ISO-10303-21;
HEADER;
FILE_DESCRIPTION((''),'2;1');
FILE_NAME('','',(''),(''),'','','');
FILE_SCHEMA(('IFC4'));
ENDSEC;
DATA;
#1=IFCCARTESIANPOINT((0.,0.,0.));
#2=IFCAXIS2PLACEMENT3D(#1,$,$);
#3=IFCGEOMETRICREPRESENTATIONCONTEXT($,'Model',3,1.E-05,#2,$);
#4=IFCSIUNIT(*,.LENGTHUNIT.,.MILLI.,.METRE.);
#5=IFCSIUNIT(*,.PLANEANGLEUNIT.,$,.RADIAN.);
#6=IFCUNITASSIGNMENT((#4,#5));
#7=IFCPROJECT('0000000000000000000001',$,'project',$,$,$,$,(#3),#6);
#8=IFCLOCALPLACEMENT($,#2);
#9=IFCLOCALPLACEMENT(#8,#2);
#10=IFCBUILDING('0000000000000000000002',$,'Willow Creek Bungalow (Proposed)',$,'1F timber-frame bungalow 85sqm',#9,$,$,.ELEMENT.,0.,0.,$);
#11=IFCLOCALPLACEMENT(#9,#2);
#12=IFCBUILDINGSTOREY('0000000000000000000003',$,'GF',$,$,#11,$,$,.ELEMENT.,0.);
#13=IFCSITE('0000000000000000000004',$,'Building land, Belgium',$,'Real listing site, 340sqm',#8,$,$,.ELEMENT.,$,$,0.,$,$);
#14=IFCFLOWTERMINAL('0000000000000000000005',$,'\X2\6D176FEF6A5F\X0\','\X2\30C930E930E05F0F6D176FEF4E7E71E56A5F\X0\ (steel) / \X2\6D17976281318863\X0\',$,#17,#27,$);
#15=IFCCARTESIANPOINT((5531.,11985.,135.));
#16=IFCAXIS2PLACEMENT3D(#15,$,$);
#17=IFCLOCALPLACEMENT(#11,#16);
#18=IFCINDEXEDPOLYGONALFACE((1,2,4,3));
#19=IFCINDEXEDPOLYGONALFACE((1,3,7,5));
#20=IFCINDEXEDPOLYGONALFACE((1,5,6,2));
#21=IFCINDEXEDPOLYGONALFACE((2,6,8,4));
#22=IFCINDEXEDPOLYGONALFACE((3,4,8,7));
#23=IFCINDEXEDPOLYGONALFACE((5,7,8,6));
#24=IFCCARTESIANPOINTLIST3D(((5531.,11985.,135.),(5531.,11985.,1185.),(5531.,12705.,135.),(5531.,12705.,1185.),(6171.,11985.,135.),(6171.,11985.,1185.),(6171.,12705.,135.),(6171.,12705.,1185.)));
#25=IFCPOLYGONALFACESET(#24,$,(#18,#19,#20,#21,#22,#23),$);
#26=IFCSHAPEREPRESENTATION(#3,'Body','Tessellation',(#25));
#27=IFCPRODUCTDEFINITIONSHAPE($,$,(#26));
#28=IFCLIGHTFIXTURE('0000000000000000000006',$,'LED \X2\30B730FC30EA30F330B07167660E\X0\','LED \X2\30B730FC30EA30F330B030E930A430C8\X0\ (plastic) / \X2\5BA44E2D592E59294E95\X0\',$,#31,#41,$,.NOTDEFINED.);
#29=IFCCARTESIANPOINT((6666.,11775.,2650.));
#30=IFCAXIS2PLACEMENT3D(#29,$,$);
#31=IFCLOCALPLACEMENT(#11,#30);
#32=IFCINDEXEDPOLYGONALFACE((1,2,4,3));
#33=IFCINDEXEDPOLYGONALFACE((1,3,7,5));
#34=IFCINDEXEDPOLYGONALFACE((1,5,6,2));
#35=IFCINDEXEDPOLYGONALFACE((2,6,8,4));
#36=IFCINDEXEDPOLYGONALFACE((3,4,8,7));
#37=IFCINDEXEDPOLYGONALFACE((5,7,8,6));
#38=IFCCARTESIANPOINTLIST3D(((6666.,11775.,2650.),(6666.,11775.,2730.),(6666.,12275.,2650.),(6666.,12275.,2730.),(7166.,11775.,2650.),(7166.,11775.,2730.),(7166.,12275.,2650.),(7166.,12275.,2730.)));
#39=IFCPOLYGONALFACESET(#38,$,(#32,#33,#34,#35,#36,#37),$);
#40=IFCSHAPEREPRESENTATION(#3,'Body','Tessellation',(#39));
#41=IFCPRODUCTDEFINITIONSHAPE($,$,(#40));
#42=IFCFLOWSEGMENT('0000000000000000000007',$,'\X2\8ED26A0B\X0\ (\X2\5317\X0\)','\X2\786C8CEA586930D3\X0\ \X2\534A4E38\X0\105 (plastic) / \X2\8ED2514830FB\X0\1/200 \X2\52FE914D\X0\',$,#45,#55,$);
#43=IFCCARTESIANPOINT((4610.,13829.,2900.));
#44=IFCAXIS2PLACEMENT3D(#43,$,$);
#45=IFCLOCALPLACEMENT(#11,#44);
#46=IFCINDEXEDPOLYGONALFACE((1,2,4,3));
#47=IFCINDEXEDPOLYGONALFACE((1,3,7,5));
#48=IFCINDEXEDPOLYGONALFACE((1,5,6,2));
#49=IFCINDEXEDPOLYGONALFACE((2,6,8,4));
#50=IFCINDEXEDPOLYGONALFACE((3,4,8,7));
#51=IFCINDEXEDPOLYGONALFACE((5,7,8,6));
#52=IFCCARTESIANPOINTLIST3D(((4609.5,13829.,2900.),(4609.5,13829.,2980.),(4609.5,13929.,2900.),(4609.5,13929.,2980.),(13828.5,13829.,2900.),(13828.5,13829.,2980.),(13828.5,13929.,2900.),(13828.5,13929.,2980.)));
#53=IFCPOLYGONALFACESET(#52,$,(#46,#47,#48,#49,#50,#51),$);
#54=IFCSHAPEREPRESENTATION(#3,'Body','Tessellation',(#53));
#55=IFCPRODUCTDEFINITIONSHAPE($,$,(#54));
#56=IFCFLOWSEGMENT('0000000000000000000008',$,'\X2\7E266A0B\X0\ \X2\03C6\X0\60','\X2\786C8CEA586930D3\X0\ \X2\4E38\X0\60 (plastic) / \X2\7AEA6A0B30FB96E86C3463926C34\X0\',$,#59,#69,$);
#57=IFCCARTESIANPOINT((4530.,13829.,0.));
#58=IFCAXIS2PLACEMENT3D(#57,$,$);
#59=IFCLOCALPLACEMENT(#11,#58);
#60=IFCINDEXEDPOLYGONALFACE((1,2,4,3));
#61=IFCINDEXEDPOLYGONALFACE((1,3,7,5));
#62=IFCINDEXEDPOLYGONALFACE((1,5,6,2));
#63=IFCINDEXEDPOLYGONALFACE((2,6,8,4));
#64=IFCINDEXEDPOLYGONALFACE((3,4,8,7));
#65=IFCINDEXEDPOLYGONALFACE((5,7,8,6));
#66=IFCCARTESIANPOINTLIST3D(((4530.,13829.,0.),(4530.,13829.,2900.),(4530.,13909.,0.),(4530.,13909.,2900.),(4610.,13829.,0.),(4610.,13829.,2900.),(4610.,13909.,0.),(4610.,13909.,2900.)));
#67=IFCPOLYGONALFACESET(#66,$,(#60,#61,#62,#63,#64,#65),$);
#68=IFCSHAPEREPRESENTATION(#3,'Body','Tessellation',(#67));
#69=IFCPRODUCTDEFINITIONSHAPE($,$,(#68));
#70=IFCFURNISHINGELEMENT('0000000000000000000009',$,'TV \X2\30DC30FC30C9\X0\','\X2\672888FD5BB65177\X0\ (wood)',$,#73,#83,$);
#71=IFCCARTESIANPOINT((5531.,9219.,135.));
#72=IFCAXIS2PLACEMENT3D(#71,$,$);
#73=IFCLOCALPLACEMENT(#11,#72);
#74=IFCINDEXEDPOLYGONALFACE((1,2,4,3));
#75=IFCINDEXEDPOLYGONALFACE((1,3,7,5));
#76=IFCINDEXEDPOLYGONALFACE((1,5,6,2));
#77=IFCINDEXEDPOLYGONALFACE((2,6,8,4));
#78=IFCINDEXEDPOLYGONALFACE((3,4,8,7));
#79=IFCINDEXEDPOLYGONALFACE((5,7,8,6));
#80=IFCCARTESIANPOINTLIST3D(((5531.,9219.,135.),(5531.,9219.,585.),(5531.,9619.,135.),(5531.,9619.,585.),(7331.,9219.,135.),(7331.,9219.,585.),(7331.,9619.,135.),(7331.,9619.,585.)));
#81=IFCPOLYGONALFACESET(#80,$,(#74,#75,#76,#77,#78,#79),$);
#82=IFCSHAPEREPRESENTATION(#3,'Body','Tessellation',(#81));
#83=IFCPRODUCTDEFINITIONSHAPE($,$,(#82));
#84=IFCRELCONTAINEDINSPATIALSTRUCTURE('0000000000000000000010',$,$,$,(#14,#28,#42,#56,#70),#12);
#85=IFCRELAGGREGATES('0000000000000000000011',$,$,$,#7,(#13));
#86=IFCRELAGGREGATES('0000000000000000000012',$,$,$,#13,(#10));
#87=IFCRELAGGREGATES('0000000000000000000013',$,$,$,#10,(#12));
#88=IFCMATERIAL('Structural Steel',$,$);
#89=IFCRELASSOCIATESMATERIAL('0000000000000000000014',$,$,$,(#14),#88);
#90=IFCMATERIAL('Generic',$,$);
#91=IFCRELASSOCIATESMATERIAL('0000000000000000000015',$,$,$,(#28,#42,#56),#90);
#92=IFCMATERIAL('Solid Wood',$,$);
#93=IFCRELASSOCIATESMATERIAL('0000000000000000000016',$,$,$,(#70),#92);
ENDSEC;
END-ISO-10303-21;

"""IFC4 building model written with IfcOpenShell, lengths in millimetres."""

from ifc_helpers import new_model, si_unit, frame, frame_2d, origin, place, context, project, spatial, rectangle, extrude, material, element, save


model = new_model("IFC4")

# Units and contexts
model_context = context("Model", 3, precision=1e-05, world=origin())
ifc_project = project(units=[si_unit("LENGTHUNIT", "METRE", prefix="MILLI"), si_unit("PLANEANGLEUNIT", "RADIAN")], contexts=[model_context])

# Site, building, storey
site_placement = place(None, origin())
site = spatial("IfcSite", under=ifc_project, at=site_placement, Name="Building land, Belgium", ObjectType="Real listing site, 340sqm", CompositionType="ELEMENT", RefElevation=0.0)
building_placement = place(site_placement, origin())
building = spatial("IfcBuilding", under=site, at=building_placement, Name="Willow Creek Bungalow (Proposed)", ObjectType="1F timber-frame bungalow 85sqm", CompositionType="ELEMENT", ElevationOfRefHeight=0.0, ElevationOfTerrain=0.0)
storey_placement = place(building_placement, origin())
storey = spatial("IfcBuildingStorey", under=building, at=storey_placement, Name="GF", CompositionType="ELEMENT", Elevation=0.0)

# Shared definitions
ifc_material_1 = material(Name="Solid Wood")

# Shared definitions
ifc_material_2 = material(Name="Generic")

# Shared definitions
ifc_material_3 = material(Name="Structural Steel")

# Flow terminal
flow_terminal_placement = place(storey_placement, frame((5531.0, 11985.0, 135.0)))
element("IfcFlowTerminal", 1, at=flow_terminal_placement, inside=storey, material=ifc_material_3, Name="洗濯機", Description="ドラム式洗濯乾燥機 (steel) / 洗面脱衣", context=model_context, shape_type="SweptSolid", body=[
    extrude(rectangle(XDim=640.0, YDim=720.0, at=frame_2d((320.0, 360.0))), frame((5531.0, 11985.0, 135.0)), (0.0, 0.0, 1.0), 1050.0),
])

# Light fixture
light_fixture_placement = place(storey_placement, frame((6666.0, 11775.0, 2650.0)))
element("IfcLightFixture", 2, at=light_fixture_placement, inside=storey, material=ifc_material_2, Name="LED シーリング照明", Description="LED シーリングライト (plastic) / 室中央天井", PredefinedType="NOTDEFINED", context=model_context, shape_type="SweptSolid", body=[
    extrude(rectangle(XDim=500.0, YDim=500.0, at=frame_2d((250.0, 250.0))), frame((6666.0, 11775.0, 2650.0)), (0.0, 0.0, 1.0), 80.0),
])

# Flow segments
flow_segment_1_placement = place(storey_placement, frame((4610.0, 13829.0, 2900.0)))
element("IfcFlowSegment", 3, at=flow_segment_1_placement, inside=storey, material=ifc_material_2, Name="軒樋 (北)", Description="硬質塩ビ 半丸105 (plastic) / 軒先・1/200 勾配", context=model_context, shape_type="SweptSolid", body=[
    extrude(rectangle(XDim=9219.0, YDim=100.0, at=frame_2d((4609.0, 50.0))), frame((4610.0, 13829.0, 2900.0)), (0.0, 0.0, 1.0), 80.0),
])
flow_segment_2_placement = place(storey_placement, frame((4530.0, 13829.0, 0.0)))
element("IfcFlowSegment", 4, at=flow_segment_2_placement, inside=storey, material=ifc_material_2, Name="縦樋 φ60", Description="硬質塩ビ 丸60 (plastic) / 竪樋・雨水排水", context=model_context, shape_type="SweptSolid", body=[
    extrude(rectangle(XDim=80.0, YDim=80.0, at=frame_2d((40.0, 40.0))), frame((4530.0, 13829.0, 0.0)), (0.0, 0.0, 1.0), 2900.0),
])

# Furnishing element
furnishing_placement = place(storey_placement, frame((5531.0, 9219.0, 135.0)))
element("IfcFurnishingElement", 5, at=furnishing_placement, inside=storey, material=ifc_material_1, Name="TV ボード", Description="木製家具 (wood)", context=model_context, shape_type="SweptSolid", body=[
    extrude(rectangle(XDim=1800.0, YDim=400.0, at=frame_2d((900.0, 200.0))), frame((5531.0, 9219.0, 135.0)), (0.0, 0.0, 1.0), 450.0),
])

save(model, "model.ifc")
